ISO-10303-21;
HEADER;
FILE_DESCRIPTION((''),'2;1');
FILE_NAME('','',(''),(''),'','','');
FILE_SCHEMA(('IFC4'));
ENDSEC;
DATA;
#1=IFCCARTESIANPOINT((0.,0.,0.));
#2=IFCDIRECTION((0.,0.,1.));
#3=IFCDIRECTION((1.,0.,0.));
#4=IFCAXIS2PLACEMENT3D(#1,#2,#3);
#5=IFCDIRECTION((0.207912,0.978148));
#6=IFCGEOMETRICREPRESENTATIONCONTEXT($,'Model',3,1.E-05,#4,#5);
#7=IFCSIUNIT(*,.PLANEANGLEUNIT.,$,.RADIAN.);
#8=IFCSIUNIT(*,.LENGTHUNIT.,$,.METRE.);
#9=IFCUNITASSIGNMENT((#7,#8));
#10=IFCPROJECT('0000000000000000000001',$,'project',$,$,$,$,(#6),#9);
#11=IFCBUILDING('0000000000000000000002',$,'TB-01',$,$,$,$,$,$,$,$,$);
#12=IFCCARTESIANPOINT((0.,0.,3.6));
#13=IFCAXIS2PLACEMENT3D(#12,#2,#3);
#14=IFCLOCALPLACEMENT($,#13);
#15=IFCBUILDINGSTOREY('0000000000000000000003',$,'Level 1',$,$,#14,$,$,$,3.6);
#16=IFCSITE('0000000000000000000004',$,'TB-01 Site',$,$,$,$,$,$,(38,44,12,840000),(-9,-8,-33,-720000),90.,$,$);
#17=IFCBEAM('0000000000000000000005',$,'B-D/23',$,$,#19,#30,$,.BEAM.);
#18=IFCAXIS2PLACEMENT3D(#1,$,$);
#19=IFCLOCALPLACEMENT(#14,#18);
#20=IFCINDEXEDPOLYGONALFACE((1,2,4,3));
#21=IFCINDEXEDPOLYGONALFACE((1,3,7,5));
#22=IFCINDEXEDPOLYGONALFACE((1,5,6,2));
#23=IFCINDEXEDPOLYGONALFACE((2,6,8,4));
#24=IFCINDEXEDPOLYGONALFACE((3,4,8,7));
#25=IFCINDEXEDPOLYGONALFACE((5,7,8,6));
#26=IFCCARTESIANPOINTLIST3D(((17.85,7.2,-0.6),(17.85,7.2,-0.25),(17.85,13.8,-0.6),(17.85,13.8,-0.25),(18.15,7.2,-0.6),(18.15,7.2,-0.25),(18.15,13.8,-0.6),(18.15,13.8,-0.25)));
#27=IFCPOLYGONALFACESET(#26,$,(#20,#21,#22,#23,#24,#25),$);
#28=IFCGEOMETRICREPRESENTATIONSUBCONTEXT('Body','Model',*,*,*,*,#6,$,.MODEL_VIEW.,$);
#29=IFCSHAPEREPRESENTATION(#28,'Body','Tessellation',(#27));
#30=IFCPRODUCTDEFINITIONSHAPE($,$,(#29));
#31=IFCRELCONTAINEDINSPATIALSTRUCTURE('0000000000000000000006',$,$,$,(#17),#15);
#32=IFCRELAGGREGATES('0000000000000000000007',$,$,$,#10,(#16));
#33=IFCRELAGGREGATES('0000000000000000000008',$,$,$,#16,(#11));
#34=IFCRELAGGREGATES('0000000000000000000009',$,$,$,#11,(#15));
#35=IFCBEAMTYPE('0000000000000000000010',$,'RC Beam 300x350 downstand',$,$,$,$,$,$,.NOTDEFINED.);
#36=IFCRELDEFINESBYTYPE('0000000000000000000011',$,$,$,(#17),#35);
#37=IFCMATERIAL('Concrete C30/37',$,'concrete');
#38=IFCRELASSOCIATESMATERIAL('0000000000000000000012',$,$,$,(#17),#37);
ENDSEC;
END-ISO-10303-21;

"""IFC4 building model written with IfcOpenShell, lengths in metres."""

from ifc_helpers import new_model, si_unit, direction, frame, origin_with_axes, place, context, subcontext, project, spatial, rectangle, extrude, material, type_object, element, save


model = new_model("IFC4")

# Units and contexts
model_context = context("Model", 3, precision=1e-05, world=origin_with_axes(), true_north=direction((0.207912, 0.978148)))
body_context = subcontext(model_context, "Body", "Model", "MODEL_VIEW")
ifc_project = project(units=[si_unit("PLANEANGLEUNIT", "RADIAN"), si_unit("LENGTHUNIT", "METRE")], contexts=[model_context])

# Site, building, storey
site = spatial("IfcSite", under=ifc_project, Name="TB-01 Site", RefLatitude=(38, 44, 12, 840000), RefLongitude=(-9, -8, -33, -720000), RefElevation=90.0)
building = spatial("IfcBuilding", under=site, Name="TB-01")
storey_placement = place(None, frame((0.0, 0.0, 3.6), z_axis=(0.0, 0.0, 1.0), x_axis=(1.0, 0.0, 0.0)))
storey = spatial("IfcBuildingStorey", under=building, at=storey_placement, Name="Level 1", Elevation=3.6)

# Beam
ifc_material = material(Name="Concrete C30/37", Category="concrete")
beam_type = type_object("IfcBeamType", Name="RC Beam 300x350 downstand", PredefinedType="NOTDEFINED")
beam_1_placement = place(storey_placement, frame((18.0, 7.2, -0.425), z_axis=(0.0, 1.0, 0.0), x_axis=(-1.0, 0.0, 0.0)))
element("IfcBeam", 1, at=beam_1_placement, inside=storey, type_object=beam_type, material=ifc_material, Name="B-D/23", PredefinedType="BEAM", context=body_context, shape_type="SweptSolid", body=[
    extrude(rectangle(XDim=0.3, YDim=0.35), origin_with_axes(), (0.0, 0.0, 1.0), 6.6),
])

save(model, "model.ifc")
